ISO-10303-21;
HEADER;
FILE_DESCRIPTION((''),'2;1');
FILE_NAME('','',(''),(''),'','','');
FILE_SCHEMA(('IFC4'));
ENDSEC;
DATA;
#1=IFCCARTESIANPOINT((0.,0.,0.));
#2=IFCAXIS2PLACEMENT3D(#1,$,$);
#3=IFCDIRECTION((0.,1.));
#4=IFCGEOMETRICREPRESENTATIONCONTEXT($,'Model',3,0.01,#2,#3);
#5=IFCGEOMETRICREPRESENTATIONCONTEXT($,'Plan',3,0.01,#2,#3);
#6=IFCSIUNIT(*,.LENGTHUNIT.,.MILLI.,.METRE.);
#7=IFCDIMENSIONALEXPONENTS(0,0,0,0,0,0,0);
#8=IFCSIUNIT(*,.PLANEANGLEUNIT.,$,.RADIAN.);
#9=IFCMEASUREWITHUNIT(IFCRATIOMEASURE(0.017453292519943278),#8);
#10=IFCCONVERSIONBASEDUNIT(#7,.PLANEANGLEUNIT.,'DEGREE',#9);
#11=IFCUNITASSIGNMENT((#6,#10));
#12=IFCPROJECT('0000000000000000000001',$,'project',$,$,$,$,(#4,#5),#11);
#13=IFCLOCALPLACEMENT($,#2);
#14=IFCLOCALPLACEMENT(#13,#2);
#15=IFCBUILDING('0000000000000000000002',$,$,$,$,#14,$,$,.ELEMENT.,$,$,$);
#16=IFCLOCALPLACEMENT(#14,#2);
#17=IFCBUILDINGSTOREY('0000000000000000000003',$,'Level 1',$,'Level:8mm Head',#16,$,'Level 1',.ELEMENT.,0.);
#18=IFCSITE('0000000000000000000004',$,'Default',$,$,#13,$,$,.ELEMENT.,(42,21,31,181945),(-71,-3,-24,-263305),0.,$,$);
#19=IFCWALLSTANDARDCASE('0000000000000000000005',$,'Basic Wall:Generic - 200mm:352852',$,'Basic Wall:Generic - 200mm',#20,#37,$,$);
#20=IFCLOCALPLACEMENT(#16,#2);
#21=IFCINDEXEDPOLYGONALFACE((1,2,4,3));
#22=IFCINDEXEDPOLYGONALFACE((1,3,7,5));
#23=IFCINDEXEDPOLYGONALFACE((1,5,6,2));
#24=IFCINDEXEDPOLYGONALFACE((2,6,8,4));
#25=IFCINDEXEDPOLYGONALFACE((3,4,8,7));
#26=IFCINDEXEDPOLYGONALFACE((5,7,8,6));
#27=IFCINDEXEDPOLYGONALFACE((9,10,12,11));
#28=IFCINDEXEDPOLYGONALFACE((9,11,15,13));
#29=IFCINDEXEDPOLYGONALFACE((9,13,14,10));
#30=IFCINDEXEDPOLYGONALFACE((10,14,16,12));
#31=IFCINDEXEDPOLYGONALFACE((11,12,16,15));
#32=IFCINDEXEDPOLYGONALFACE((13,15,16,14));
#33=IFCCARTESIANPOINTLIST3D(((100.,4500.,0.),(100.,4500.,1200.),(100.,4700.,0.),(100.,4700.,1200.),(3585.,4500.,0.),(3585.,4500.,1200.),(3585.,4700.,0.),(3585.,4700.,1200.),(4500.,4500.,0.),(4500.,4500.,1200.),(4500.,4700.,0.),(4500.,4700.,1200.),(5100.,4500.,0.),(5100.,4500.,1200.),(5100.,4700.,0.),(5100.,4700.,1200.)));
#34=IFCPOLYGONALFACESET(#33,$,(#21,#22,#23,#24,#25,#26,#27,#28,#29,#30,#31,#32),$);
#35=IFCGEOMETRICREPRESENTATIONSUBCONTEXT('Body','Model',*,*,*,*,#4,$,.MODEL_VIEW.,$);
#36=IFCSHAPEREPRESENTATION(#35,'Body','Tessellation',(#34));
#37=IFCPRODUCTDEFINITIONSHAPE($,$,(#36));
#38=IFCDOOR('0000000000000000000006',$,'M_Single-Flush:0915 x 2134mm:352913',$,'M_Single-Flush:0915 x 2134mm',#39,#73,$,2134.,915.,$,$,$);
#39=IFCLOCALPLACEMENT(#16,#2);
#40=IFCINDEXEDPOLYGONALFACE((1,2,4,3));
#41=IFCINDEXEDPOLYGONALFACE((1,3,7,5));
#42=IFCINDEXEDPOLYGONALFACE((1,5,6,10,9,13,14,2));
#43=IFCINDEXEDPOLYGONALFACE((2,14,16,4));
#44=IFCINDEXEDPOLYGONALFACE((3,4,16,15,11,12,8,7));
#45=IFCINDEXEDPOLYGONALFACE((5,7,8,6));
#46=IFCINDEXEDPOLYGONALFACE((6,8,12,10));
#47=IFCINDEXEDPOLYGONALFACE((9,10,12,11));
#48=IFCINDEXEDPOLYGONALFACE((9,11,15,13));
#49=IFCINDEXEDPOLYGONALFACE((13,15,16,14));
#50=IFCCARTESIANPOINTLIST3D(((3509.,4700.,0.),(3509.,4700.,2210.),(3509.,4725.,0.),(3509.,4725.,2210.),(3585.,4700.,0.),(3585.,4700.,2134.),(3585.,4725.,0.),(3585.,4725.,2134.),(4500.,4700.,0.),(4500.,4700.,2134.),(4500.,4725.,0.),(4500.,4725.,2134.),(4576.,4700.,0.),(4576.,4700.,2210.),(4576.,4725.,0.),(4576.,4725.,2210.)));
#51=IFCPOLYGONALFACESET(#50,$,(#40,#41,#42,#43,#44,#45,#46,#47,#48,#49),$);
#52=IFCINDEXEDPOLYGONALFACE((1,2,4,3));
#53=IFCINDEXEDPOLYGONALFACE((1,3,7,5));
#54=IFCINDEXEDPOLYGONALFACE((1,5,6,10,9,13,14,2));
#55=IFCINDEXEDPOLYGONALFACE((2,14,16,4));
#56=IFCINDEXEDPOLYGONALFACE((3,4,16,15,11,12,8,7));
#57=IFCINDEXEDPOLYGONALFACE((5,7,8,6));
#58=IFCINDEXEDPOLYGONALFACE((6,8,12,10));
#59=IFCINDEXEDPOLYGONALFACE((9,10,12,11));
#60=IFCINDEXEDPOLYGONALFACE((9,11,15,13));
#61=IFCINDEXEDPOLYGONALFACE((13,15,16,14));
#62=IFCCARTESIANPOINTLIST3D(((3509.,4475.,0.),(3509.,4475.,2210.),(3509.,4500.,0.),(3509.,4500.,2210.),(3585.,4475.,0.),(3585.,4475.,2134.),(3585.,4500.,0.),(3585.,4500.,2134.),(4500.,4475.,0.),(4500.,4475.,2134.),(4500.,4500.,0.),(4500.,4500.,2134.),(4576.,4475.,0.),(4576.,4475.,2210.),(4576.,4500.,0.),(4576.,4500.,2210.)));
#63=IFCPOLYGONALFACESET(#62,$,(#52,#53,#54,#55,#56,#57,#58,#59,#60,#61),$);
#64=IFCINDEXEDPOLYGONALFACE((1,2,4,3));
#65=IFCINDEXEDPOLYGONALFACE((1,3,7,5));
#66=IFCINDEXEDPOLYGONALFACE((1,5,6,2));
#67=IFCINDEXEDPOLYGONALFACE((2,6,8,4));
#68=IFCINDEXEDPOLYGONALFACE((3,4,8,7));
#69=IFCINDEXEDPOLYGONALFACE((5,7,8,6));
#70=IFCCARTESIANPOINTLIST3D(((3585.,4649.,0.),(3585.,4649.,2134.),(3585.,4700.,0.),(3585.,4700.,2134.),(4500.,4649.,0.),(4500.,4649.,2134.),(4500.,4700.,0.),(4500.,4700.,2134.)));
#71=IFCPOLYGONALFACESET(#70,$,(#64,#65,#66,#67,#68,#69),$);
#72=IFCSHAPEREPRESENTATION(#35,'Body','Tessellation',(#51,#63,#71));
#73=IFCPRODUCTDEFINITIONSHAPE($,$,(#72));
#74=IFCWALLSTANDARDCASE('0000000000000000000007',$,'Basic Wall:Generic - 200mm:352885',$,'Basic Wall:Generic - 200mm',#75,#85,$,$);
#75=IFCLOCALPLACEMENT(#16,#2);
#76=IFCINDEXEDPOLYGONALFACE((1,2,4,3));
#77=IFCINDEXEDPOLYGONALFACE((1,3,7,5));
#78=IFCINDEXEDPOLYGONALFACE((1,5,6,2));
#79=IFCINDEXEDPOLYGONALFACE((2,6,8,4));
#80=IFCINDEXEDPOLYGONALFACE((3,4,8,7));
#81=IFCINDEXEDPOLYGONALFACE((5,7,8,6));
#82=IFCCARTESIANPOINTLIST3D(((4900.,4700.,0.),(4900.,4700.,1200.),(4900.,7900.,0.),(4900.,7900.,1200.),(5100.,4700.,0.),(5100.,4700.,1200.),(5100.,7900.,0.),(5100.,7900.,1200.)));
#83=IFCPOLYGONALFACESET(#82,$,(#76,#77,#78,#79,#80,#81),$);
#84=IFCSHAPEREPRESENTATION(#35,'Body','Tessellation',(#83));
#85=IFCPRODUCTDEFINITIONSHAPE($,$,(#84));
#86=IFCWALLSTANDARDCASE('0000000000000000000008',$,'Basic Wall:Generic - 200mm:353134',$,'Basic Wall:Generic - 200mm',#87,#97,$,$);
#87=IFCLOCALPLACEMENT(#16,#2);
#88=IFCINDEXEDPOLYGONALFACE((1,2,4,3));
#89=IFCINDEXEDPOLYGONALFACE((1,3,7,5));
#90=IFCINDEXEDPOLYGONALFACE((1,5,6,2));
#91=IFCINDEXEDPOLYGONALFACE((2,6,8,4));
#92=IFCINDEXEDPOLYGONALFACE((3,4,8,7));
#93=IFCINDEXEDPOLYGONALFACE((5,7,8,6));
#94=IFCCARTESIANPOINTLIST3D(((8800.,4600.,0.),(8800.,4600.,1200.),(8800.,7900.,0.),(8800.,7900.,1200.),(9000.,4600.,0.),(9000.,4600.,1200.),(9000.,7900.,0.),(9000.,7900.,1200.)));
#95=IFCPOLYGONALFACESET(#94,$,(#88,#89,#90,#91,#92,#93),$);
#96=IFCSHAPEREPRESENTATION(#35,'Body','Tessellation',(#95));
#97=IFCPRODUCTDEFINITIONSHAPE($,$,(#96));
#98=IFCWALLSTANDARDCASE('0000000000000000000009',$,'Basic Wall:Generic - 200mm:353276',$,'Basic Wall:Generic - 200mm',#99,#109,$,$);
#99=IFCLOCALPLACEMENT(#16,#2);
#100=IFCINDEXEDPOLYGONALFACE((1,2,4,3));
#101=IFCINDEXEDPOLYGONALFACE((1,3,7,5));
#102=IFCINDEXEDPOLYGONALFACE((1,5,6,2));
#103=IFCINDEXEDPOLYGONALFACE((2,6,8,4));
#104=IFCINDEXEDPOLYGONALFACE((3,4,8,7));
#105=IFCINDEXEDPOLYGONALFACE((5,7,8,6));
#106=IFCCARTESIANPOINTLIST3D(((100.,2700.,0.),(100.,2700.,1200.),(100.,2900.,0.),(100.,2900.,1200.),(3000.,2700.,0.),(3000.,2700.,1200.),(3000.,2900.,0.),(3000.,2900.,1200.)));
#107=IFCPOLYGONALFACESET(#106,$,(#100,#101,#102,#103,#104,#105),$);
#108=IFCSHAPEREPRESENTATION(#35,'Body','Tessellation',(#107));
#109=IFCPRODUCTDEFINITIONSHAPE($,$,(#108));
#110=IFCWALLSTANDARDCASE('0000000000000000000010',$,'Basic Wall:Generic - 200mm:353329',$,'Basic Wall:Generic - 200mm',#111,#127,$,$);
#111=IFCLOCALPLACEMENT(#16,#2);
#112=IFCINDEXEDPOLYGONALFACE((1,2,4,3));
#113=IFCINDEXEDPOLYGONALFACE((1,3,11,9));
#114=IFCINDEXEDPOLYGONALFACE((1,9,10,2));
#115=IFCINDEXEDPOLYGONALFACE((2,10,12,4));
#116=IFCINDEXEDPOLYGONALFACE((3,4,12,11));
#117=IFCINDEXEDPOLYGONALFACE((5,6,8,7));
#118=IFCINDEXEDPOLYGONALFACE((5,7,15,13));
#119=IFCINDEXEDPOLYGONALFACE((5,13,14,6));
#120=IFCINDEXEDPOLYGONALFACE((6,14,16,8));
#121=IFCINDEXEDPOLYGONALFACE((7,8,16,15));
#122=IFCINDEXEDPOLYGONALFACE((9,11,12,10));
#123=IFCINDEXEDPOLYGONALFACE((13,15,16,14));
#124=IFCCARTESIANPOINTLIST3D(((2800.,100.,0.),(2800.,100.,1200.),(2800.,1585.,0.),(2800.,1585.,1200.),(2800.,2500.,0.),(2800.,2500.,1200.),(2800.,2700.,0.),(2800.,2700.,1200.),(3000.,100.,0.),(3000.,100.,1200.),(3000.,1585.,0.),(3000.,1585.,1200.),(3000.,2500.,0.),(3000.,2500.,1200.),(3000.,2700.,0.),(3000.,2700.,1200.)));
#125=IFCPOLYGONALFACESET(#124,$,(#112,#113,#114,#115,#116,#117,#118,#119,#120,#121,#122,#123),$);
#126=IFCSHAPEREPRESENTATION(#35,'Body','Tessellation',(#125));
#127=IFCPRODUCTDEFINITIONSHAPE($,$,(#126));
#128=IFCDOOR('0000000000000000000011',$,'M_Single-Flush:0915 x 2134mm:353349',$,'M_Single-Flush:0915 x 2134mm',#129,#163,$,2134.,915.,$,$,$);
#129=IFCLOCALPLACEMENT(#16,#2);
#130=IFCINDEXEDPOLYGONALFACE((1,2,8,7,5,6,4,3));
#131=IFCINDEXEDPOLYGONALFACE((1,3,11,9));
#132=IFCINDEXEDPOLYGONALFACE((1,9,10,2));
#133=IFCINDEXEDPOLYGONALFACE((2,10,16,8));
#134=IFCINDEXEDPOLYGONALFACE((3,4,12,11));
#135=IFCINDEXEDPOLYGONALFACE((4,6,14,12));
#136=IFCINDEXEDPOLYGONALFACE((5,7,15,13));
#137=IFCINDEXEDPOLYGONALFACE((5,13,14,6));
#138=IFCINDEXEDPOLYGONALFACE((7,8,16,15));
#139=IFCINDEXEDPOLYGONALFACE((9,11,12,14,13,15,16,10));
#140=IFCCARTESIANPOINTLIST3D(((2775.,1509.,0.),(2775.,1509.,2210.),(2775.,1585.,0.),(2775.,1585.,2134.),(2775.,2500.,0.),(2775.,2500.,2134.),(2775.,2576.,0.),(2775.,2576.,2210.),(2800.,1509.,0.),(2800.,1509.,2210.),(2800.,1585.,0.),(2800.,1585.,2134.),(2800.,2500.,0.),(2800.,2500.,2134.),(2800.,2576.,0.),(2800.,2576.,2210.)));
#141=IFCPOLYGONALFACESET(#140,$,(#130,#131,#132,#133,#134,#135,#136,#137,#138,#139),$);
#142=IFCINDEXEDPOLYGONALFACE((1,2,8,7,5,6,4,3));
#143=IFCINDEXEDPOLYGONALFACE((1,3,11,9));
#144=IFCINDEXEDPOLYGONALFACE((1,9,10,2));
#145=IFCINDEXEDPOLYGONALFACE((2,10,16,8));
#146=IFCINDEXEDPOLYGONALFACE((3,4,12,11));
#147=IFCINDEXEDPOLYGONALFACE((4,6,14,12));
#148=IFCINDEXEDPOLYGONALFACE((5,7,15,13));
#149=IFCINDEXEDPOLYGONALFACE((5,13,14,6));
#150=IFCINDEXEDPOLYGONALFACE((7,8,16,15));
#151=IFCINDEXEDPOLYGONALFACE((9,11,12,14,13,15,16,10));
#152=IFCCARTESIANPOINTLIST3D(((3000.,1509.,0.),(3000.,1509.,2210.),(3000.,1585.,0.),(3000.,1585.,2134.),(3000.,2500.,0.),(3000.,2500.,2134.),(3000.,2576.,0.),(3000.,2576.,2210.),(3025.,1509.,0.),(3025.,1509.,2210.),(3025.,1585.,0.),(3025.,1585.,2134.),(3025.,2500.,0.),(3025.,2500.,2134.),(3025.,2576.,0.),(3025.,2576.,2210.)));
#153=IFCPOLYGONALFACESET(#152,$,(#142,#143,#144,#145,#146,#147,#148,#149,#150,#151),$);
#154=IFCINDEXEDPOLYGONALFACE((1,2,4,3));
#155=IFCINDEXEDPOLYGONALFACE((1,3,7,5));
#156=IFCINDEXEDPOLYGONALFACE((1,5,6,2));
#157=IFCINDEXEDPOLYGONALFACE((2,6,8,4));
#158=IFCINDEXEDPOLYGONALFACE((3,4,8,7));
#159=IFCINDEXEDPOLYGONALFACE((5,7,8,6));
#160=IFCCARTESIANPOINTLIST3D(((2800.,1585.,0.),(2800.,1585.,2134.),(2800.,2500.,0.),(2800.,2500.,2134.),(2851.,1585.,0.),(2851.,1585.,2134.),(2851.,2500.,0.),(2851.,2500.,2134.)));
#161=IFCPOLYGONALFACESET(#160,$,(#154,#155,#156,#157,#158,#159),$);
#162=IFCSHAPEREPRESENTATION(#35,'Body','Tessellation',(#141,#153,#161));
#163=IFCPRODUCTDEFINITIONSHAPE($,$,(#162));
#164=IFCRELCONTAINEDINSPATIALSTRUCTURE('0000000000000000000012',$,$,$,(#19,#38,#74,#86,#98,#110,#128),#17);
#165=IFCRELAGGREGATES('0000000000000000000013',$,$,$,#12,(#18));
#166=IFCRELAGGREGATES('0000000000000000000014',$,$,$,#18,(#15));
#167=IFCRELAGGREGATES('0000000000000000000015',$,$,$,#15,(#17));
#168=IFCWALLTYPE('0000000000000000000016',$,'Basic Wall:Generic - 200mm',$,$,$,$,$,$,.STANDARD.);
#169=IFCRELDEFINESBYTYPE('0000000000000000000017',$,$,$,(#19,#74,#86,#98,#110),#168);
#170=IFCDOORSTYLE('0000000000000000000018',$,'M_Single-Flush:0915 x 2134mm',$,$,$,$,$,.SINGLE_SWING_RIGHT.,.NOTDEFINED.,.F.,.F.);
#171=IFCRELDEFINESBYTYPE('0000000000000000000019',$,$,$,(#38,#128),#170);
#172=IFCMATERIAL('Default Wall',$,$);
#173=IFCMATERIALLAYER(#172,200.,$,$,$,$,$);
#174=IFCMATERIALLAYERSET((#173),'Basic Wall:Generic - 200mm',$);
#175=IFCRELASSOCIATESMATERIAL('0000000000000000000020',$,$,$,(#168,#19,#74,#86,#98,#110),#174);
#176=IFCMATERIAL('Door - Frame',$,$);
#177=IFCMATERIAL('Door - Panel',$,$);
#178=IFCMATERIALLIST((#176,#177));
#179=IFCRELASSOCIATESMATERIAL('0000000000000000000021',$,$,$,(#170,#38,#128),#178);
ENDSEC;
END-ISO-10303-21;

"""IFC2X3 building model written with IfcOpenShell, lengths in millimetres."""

from ifc_helpers import new_model, entity, si_unit, converted_unit, direction, frame, frame_2d, origin, place, context, subcontext, project, spatial, polyline, rectangle, outline, extrude, clip, bounded_halfspace, source, transform, mapped, material, material_list, layer, layer_set, layer_usage, type_object, type_shapes, element, fill, save


model = new_model("IFC2X3")

# Units and contexts
model_context = context("Model", 3, precision=0.01, world=origin(), true_north=direction((0.0, 1.0)))
plan_context = context("Plan", 3, precision=0.01, world=origin(), true_north=direction((0.0, 1.0)))
body_context = subcontext(model_context, "Body", "Model", "MODEL_VIEW")
ifc_project = project(units=[si_unit("LENGTHUNIT", "METRE", prefix="MILLI"), converted_unit("PLANEANGLEUNIT", "DEGREE", entity("IfcRatioMeasure", 0.017453292519943278), si_unit("PLANEANGLEUNIT", "RADIAN"), dimensions=[0, 0, 0, 0, 0, 0, 0])], contexts=[model_context, plan_context])

# Site, building, storey
site_placement = place(None, origin())
site = spatial("IfcSite", under=ifc_project, at=site_placement, Name="Default", CompositionType="ELEMENT", RefLatitude=(42, 21, 31, 181945), RefLongitude=(-71, -3, -24, -263305), RefElevation=0.0)
building_placement = place(site_placement, origin())
building = spatial("IfcBuilding", under=site, at=building_placement, CompositionType="ELEMENT")
storey_placement = place(building_placement, origin())
storey = spatial("IfcBuildingStorey", under=building, at=storey_placement, Name="Level 1", ObjectType="Level:8mm Head", LongName="Level 1", CompositionType="ELEMENT", Elevation=0.0)

# Shared definitions
ifc_material_1 = material(Name="Default Wall")
ifc_layer_1 = layer(ifc_material_1, 200.0)
ifc_layer_set_1 = layer_set([ifc_layer_1], Name="Basic Wall:Generic - 200mm")
ifc_layer_usage_1 = layer_usage(ifc_layer_set_1, "AXIS2", "NEGATIVE", 100.0)
wall_type = type_object("IfcWallType", Name="Basic Wall:Generic - 200mm", PredefinedType="STANDARD", material=ifc_layer_set_1)
ifc_material_2 = material(Name="Door - Frame")
ifc_material_3 = material(Name="Door - Panel")
ifc_material_list = material_list([ifc_material_2, ifc_material_3])
door_style = type_object("IfcDoorStyle", Name="M_Single-Flush:0915 x 2134mm", ConstructionType="NOTDEFINED", OperationType="SINGLE_SWING_RIGHT", ParameterTakesPrecedence=False, Sizeable=False, material=ifc_material_list)
shared_shape = source(origin(), body_context, "Body", "SweptSolid", [
    extrude(outline(polyline([(-533.5, -1124.0), (533.5, -1124.0), (533.5, 1086.0), (457.5, 1086.0), (457.5, -1048.0), (-457.5, -1048.0), (-457.5, 1086.0), (-533.5, 1086.0), (-533.5, -1124.0)])), frame((457.5, 200.0, 1086.0), z_axis=(0.0, 1.0, 0.0), x_axis=(1.0, 0.0, 0.0)), (0.0, 0.0, 1.0), 25.0),
    extrude(outline(polyline([(-1124.0, -533.5), (1086.0, -533.5), (1086.0, -457.5), (-1048.0, -457.5), (-1048.0, 457.5), (1086.0, 457.5), (1086.0, 533.5), (-1124.0, 533.5), (-1124.0, -533.5)])), frame((457.5, -25.0, 1086.0), z_axis=(0.0, 1.0, 0.0), x_axis=(0.0, 0.0, -1.0)), (0.0, 0.0, 1.0), 25.0),
    extrude(rectangle(XDim=51.0, YDim=915.0, at=frame_2d((0.0, 0.0), x_axis=(1.0, 0.0))), frame((457.5, 174.5, 0.0), z_axis=(0.0, 0.0, 1.0), x_axis=(0.0, 1.0, 0.0)), (0.0, 0.0, 1.0), 2134.0),
])
type_shapes(door_style, [shared_shape])

# Wall, opening, door
wall_1_placement = place(storey_placement, frame((100.0, 4600.0, 0.0)))
wall_1 = element("IfcWallStandardCase", 1, at=wall_1_placement, inside=storey, type_object=wall_type, material=ifc_layer_usage_1, Name="Basic Wall:Generic - 200mm:352852", ObjectType="Basic Wall:Generic - 200mm", context=body_context, shape_type="Clipping", body=[
    clip(extrude(rectangle(XDim=5000.0, YDim=200.0, at=frame_2d((2500.0, 0.0), x_axis=(1.0, 0.0))), origin(), (0.0, 0.0, 1.0), 1200.0), bounded_halfspace(frame((0.0, -100.0, 3850.0), z_axis=(0.0, 0.0, -1.0), x_axis=(0.0, -1.0, 0.0)), True, frame((0.0, -100.0, 3850.0)), polyline([(0.0, 0.0), (5000.0, 0.0), (5000.0, 200.0), (4800.0, 200.0), (0.0, 200.0), (0.0, 0.0)]))),
])
opening_1_placement = place(wall_1_placement, frame((3485.0, -100.0, 0.0)))
opening_1 = element("IfcOpeningElement", 2, at=opening_1_placement, cuts=wall_1, ObjectType="Opening", context=body_context, shape_type="SweptSolid", body=[
    extrude(rectangle(XDim=915.0, YDim=2134.0, at=frame_2d((1067.0, 457.5), x_axis=(0.0, 1.0))), frame((0.0, 0.0, 0.0), z_axis=(0.0, 1.0, 0.0), x_axis=(0.0, 0.0, 1.0)), (0.0, 0.0, 1.0), 200.0),
])
door_1_placement = place(opening_1_placement, origin())
door_1 = element("IfcDoor", 3, at=door_1_placement, inside=storey, type_object=door_style, material=ifc_material_list, Name="M_Single-Flush:0915 x 2134mm:352913", ObjectType="M_Single-Flush:0915 x 2134mm", OverallHeight=2134.0, OverallWidth=915.0, context=body_context, shape_type="MappedRepresentation", body=[
    mapped(shared_shape, transform((0.0, 0.0, 0.0), scale=1.0)),
])
fill(opening_1, door_1)

# Walls
wall_2_placement = place(storey_placement, frame((5000.0, 4700.0, 0.0), z_axis=(0.0, 0.0, 1.0), x_axis=(0.0, 1.0, 0.0)))
element("IfcWallStandardCase", 4, at=wall_2_placement, inside=storey, type_object=wall_type, material=ifc_layer_usage_1, Name="Basic Wall:Generic - 200mm:352885", ObjectType="Basic Wall:Generic - 200mm", context=body_context, shape_type="Clipping", body=[
    clip(extrude(rectangle(XDim=3200.0, YDim=200.0, at=frame_2d((1600.0, 0.0), x_axis=(-1.0, 0.0))), origin(), (0.0, 0.0, 1.0), 1200.0), bounded_halfspace(frame((0.0, -100.0, 3850.0), z_axis=(0.0, 0.0, -1.0), x_axis=(-1.0, 0.0, 0.0)), True, frame((0.0, -100.0, 3850.0)), polyline([(0.0, 0.0), (3200.0, 0.0), (3200.0, 200.0), (0.0, 200.0), (0.0, 0.0)]))),
])
wall_3_placement = place(storey_placement, frame((8900.0, 7900.0, 0.0), z_axis=(0.0, 0.0, 1.0), x_axis=(0.0, -1.0, 0.0)))
element("IfcWallStandardCase", 5, at=wall_3_placement, inside=storey, type_object=wall_type, material=ifc_layer_usage_1, Name="Basic Wall:Generic - 200mm:353134", ObjectType="Basic Wall:Generic - 200mm", context=body_context, shape_type="Clipping", body=[
    clip(extrude(rectangle(XDim=3300.0, YDim=200.0, at=frame_2d((1650.0, 0.0), x_axis=(-1.0, 0.0))), origin(), (0.0, 0.0, 1.0), 1200.0), bounded_halfspace(frame((0.0, -100.0, 3850.0), z_axis=(0.0, 0.0, -1.0), x_axis=(1.0, 0.0, 0.0)), True, frame((0.0, -100.0, 3850.0)), polyline([(0.0, 0.0), (3300.0, 0.0), (3300.0, 200.0), (0.0, 200.0), (0.0, 0.0)]))),
])
wall_4_placement = place(storey_placement, frame((100.0, 2800.0, 0.0)))
element("IfcWallStandardCase", 6, at=wall_4_placement, inside=storey, type_object=wall_type, material=ifc_layer_usage_1, Name="Basic Wall:Generic - 200mm:353276", ObjectType="Basic Wall:Generic - 200mm", context=body_context, shape_type="Clipping", body=[
    clip(extrude(rectangle(XDim=2900.0, YDim=200.0, at=frame_2d((1450.0, 0.0), x_axis=(-1.0, 0.0))), origin(), (0.0, 0.0, 1.0), 1200.0), bounded_halfspace(frame((0.0, -100.0, 3850.0), z_axis=(0.0, 0.0, -1.0), x_axis=(0.0, -1.0, 0.0)), True, frame((0.0, -100.0, 3850.0)), polyline([(0.0, 0.0), (2700.0, 0.0), (2900.0, 0.0), (2900.0, 200.0), (0.0, 200.0), (0.0, 0.0)]))),
])

# Wall, opening, door
wall_5_placement = place(storey_placement, frame((2900.0, 2700.0, 0.0), z_axis=(0.0, 0.0, 1.0), x_axis=(0.0, -1.0, 0.0)))
wall_5 = element("IfcWallStandardCase", 7, at=wall_5_placement, inside=storey, type_object=wall_type, material=ifc_layer_usage_1, Name="Basic Wall:Generic - 200mm:353329", ObjectType="Basic Wall:Generic - 200mm", context=body_context, shape_type="Clipping", body=[
    clip(extrude(rectangle(XDim=2600.0, YDim=200.0, at=frame_2d((1300.0, 0.0), x_axis=(1.0, 0.0))), origin(), (0.0, 0.0, 1.0), 1200.0), bounded_halfspace(frame((0.0, -100.0, 3850.0), z_axis=(0.0, 0.0, -1.0), x_axis=(1.0, 0.0, 0.0)), True, frame((0.0, -100.0, 3850.0)), polyline([(0.0, 0.0), (2600.0, 0.0), (2600.0, 200.0), (0.0, 200.0), (0.0, 0.0)]))),
])
opening_2_placement = place(wall_5_placement, frame((1115.0, 100.0, 0.0)))
opening_2 = element("IfcOpeningElement", 8, at=opening_2_placement, cuts=wall_5, ObjectType="Opening", context=body_context, shape_type="SweptSolid", body=[
    extrude(rectangle(XDim=915.0, YDim=2134.0, at=frame_2d((1067.0, 457.5), x_axis=(0.0, 1.0))), frame((0.0, 0.0, 0.0), z_axis=(0.0, -1.0, 0.0), x_axis=(0.0, 0.0, 1.0)), (0.0, 0.0, 1.0), 200.0),
])
door_2_placement = place(opening_2_placement, frame((0.0, 0.0, 0.0), z_axis=(0.0, 0.0, 1.0), x_axis=(-1.0, 0.0, 0.0)))
door_2 = element("IfcDoor", 9, at=door_2_placement, inside=storey, type_object=door_style, material=ifc_material_list, Name="M_Single-Flush:0915 x 2134mm:353349", ObjectType="M_Single-Flush:0915 x 2134mm", OverallHeight=2134.0, OverallWidth=915.0, context=body_context, shape_type="MappedRepresentation", body=[
    mapped(shared_shape, transform((0.0, 0.0, 0.0), scale=1.0)),
])
fill(opening_2, door_2)

save(model, "model.ifc")
